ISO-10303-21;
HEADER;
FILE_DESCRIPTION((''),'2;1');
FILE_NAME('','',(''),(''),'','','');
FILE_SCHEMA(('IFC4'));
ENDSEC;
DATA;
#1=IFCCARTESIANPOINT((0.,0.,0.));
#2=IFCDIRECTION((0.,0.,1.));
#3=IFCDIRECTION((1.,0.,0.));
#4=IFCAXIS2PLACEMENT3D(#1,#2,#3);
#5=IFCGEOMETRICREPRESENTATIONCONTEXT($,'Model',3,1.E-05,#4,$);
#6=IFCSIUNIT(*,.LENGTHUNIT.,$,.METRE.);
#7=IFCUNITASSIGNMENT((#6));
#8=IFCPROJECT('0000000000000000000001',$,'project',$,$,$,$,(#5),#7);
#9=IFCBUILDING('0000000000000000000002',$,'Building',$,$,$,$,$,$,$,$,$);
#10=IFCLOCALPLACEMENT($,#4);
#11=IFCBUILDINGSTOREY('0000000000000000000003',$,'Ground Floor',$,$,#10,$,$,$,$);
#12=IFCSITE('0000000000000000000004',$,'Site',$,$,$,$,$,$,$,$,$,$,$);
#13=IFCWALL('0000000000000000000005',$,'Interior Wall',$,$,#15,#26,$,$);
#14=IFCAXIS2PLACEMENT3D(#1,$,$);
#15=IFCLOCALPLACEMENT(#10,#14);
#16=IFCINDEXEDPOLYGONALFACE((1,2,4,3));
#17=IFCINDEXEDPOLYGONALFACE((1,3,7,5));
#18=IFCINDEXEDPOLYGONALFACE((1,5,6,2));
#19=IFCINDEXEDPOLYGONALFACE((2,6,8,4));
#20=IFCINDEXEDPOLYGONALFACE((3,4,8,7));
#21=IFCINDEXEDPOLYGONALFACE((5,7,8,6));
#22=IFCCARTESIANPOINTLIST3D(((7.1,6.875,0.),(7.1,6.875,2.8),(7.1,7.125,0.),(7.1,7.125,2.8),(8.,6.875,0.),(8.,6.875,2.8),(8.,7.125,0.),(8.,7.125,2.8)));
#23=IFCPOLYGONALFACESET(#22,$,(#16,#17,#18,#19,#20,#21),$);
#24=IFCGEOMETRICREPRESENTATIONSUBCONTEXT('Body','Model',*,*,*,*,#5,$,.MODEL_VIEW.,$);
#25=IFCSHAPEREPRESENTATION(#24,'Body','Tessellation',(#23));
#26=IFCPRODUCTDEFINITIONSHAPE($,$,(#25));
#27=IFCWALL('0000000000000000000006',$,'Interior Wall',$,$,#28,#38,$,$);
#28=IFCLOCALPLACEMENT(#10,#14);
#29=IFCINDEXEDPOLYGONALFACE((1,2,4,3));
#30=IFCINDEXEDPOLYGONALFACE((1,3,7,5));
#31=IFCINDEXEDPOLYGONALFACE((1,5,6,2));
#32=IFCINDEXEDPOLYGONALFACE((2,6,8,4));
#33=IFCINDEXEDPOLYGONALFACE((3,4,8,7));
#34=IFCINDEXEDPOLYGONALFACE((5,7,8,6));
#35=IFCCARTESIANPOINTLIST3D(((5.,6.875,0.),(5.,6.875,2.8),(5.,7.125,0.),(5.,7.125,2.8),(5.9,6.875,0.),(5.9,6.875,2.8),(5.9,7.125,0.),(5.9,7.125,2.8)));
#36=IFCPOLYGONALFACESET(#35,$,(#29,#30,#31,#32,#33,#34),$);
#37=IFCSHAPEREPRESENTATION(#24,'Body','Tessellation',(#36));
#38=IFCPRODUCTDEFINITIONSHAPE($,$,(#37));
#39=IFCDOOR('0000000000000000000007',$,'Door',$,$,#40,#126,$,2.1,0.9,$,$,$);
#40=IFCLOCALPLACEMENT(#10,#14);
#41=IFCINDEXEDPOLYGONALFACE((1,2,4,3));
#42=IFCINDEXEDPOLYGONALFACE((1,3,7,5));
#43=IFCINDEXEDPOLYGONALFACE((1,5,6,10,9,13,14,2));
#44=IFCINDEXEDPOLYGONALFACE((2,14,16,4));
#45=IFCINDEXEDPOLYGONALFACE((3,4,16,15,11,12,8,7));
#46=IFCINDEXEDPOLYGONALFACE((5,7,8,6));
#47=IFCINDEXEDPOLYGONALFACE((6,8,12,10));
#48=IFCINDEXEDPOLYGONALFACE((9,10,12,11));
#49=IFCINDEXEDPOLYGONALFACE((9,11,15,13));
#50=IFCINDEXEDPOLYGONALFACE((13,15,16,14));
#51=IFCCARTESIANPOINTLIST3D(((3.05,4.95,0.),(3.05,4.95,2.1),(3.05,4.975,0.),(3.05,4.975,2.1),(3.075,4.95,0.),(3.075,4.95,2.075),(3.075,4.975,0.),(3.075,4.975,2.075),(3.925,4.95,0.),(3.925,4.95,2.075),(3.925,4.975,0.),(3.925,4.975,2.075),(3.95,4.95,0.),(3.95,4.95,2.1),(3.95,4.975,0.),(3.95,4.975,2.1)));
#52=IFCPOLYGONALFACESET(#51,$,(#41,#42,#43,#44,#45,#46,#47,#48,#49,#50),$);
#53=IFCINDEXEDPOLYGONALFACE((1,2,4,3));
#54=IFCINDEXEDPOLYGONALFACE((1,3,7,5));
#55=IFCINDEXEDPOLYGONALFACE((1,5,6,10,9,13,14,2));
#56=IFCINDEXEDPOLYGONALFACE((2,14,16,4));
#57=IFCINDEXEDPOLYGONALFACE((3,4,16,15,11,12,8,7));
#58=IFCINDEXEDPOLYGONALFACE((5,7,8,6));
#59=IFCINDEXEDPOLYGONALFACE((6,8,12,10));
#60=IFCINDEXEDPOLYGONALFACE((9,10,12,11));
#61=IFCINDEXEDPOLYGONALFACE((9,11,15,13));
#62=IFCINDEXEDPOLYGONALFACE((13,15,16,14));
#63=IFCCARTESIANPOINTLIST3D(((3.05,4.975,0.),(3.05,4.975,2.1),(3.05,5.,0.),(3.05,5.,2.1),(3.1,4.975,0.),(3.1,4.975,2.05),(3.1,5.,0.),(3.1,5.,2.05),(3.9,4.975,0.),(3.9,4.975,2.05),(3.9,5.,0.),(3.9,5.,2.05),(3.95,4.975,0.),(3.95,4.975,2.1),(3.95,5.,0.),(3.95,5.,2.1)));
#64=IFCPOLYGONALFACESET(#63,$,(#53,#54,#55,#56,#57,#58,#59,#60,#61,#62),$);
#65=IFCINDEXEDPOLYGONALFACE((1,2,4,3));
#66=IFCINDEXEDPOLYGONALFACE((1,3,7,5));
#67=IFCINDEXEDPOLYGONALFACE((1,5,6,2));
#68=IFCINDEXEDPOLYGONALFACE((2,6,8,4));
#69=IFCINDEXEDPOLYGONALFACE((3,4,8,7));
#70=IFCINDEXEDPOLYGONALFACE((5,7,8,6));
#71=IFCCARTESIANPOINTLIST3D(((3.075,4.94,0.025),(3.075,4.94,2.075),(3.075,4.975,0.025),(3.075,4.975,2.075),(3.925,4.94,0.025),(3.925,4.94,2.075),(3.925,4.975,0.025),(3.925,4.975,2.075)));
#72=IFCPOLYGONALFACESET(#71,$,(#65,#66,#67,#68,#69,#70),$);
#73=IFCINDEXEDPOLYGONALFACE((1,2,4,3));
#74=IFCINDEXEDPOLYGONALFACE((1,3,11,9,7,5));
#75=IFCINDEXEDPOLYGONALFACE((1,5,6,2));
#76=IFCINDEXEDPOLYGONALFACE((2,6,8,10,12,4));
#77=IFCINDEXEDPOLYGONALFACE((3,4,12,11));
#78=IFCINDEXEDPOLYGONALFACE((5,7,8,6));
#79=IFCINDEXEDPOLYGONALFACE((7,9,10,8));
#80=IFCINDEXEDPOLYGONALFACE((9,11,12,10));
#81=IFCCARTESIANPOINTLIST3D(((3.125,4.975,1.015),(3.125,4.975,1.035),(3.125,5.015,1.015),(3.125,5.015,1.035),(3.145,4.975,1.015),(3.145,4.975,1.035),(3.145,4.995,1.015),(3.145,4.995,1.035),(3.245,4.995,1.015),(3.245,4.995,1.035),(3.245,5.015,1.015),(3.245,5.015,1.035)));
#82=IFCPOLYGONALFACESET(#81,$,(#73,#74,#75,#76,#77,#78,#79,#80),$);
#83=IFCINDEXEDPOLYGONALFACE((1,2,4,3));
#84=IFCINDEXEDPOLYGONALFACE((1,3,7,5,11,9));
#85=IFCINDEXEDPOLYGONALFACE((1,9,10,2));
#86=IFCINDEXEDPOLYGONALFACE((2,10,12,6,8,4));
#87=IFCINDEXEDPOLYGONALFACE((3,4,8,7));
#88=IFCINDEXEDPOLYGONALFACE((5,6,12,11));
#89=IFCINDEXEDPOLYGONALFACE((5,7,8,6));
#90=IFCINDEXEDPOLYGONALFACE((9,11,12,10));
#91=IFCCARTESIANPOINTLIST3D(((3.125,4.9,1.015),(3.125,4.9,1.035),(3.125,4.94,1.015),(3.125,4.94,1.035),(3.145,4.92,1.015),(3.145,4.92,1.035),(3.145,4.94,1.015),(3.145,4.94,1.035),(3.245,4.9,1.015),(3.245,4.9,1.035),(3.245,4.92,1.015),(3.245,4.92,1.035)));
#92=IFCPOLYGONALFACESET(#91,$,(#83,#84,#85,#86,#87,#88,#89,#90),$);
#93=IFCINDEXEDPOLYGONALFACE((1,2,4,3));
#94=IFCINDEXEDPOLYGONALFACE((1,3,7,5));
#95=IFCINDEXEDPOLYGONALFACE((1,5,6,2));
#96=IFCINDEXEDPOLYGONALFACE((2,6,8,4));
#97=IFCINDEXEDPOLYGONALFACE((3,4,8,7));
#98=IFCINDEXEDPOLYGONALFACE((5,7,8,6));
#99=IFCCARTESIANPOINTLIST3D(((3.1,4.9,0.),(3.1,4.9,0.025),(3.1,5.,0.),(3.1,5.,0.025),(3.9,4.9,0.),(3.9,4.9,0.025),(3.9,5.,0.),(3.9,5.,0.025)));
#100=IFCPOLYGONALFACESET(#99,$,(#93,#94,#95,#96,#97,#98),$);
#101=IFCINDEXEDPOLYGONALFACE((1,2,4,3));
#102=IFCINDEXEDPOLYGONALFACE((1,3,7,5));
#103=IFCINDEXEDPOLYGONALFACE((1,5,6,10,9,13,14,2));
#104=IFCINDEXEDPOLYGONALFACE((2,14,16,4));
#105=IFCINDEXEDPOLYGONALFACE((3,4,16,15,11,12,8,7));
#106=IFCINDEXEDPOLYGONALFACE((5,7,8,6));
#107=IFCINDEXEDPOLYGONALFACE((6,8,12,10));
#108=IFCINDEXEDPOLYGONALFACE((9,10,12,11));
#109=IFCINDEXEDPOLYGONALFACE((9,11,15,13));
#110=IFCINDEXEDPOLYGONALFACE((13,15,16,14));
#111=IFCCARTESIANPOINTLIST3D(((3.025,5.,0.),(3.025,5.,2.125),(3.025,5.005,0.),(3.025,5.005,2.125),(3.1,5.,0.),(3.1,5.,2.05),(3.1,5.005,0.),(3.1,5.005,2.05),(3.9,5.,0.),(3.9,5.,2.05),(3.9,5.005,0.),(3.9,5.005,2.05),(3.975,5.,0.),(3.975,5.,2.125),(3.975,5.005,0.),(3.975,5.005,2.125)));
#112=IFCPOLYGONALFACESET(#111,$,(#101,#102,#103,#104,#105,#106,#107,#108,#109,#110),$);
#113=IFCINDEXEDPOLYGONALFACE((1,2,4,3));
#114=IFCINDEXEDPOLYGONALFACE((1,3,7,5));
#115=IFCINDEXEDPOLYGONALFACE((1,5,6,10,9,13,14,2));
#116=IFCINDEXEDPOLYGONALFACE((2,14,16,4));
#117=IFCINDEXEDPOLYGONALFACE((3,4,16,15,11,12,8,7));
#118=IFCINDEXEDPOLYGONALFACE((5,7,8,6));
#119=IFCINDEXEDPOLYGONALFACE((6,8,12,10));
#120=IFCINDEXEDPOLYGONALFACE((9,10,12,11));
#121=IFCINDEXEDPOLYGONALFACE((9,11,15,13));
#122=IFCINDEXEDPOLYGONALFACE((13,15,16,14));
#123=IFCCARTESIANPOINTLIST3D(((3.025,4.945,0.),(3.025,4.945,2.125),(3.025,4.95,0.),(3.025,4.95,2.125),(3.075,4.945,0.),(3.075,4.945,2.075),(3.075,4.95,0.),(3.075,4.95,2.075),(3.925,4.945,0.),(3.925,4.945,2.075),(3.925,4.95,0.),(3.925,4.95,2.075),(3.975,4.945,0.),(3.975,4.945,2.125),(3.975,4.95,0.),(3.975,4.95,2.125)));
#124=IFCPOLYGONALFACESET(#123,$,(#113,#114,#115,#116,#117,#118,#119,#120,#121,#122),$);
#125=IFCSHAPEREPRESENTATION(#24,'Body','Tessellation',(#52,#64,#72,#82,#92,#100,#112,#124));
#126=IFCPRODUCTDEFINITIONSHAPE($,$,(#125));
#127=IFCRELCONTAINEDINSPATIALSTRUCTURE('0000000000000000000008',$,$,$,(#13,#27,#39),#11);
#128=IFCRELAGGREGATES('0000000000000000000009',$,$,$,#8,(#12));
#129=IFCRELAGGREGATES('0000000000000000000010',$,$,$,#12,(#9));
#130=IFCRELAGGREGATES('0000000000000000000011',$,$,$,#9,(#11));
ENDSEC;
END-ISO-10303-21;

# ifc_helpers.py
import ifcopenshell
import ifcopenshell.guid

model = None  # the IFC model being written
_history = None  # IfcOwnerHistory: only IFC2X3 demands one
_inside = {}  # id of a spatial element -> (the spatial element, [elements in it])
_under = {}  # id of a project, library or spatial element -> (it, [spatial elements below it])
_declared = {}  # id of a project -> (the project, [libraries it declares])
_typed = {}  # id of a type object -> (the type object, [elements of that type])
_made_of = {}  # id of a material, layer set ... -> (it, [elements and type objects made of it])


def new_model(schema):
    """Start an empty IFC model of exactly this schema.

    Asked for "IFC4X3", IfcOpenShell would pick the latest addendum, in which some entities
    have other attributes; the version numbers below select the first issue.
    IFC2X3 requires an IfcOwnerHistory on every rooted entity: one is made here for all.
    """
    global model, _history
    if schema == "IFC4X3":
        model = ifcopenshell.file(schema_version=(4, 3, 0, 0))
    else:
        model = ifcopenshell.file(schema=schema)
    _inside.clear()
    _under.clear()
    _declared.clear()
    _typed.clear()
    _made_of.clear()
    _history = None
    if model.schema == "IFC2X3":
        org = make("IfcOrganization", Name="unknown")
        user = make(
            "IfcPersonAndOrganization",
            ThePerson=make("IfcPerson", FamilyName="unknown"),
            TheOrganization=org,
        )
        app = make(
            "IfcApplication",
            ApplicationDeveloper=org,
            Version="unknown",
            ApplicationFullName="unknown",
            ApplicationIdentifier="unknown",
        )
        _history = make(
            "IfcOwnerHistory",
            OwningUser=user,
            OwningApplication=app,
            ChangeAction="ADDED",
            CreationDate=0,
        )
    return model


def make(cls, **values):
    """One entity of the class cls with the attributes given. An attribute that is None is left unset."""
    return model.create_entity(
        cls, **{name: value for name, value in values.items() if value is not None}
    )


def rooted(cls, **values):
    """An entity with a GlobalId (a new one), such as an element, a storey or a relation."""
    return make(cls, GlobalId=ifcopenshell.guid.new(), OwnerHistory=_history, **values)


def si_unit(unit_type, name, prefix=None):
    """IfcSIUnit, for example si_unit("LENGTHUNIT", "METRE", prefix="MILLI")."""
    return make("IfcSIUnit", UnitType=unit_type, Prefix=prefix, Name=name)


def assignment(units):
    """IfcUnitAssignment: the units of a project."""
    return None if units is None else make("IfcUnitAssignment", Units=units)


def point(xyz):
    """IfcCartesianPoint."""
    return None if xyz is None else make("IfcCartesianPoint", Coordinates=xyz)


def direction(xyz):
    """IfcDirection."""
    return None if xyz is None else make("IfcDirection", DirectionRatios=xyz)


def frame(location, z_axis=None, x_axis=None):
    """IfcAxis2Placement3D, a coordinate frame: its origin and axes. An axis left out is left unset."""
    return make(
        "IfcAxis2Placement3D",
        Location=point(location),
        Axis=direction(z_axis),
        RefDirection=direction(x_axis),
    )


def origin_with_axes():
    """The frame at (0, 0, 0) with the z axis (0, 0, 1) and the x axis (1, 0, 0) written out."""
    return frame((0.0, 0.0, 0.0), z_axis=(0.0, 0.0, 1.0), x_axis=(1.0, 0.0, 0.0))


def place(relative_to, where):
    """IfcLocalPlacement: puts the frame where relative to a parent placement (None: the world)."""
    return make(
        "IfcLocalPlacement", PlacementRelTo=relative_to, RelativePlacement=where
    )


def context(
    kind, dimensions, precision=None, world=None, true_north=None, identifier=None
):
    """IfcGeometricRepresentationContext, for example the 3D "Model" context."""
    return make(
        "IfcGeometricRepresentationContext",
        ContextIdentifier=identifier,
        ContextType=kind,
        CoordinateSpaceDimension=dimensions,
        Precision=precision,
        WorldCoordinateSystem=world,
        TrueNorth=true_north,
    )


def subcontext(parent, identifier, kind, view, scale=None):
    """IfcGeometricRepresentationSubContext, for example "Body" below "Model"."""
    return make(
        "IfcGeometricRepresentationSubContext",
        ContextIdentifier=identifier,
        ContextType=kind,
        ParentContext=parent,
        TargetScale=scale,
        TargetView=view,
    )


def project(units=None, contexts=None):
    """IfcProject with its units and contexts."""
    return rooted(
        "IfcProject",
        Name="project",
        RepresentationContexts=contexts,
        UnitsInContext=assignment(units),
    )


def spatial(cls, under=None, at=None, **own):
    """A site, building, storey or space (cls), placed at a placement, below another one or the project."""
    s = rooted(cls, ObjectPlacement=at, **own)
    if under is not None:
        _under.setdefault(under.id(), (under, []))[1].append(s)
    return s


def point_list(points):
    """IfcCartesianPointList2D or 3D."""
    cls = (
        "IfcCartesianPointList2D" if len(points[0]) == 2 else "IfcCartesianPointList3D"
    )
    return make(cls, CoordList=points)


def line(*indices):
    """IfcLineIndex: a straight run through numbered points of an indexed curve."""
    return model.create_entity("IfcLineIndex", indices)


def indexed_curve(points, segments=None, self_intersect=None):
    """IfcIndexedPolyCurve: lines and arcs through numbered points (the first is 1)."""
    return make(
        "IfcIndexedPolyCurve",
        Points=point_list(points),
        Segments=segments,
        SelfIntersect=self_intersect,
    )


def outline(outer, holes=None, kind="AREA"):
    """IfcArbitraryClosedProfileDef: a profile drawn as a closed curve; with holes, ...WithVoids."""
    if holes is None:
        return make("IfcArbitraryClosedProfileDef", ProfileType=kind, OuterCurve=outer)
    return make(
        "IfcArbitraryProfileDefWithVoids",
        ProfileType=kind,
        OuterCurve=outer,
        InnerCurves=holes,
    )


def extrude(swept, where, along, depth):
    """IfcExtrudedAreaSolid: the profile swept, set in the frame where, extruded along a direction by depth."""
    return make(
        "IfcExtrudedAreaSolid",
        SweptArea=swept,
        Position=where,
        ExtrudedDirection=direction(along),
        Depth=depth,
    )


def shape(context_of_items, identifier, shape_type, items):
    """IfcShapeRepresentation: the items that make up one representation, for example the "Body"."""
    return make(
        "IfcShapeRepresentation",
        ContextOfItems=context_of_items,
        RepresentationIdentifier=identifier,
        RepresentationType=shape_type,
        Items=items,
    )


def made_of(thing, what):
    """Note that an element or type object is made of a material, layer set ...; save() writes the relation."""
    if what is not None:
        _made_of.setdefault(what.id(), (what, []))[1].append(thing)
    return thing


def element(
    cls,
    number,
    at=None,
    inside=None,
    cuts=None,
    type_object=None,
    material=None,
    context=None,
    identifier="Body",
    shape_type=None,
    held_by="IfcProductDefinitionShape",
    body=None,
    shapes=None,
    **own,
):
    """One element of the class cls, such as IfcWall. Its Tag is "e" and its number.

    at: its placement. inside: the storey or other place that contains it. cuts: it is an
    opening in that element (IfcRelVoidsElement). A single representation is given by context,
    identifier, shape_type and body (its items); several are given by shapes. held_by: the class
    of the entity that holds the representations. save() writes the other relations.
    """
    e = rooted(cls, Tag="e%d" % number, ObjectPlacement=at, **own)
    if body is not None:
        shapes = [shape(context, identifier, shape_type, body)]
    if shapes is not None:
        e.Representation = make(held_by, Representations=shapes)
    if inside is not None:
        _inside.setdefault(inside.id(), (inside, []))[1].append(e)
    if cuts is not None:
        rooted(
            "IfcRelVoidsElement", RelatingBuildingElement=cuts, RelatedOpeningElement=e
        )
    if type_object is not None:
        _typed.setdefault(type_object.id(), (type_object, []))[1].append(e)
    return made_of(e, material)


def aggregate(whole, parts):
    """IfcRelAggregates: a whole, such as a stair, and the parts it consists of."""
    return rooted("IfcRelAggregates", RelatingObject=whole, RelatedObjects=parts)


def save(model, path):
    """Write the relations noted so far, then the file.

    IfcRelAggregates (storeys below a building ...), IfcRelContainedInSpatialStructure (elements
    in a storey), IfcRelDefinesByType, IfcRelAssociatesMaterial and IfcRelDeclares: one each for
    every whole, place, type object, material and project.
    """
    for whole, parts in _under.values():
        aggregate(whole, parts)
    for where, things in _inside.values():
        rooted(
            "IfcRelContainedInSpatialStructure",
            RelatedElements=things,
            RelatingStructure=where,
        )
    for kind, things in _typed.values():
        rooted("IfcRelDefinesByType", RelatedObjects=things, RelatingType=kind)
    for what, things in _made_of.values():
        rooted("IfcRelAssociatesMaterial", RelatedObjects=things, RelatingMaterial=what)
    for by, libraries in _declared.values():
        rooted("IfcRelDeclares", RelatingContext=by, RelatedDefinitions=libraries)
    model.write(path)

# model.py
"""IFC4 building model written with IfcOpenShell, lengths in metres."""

from ifc_helpers import new_model, si_unit, frame, origin_with_axes, place, context, subcontext, project, spatial, line, indexed_curve, outline, extrude, element, save


model = new_model("IFC4")

# Units and contexts
model_context = context("Model", 3, precision=1e-05, world=origin_with_axes())
body_context = subcontext(model_context, "Body", "Model", "MODEL_VIEW")
ifc_project = project(units=[si_unit("LENGTHUNIT", "METRE")], contexts=[model_context])

# Site, building, storey
site = spatial("IfcSite", under=ifc_project, Name="Site")
building = spatial("IfcBuilding", under=site, Name="Building")
storey_placement = place(None, origin_with_axes())
storey = spatial("IfcBuildingStorey", under=building, at=storey_placement, Name="Ground Floor")

# Walls
for number, where, z_axis, x_axis, name in (
    (1, (8.0, 7.0, 0.0), (0.0, 0.0, 1.0), (-1.0, 0.0, 0.0), "Interior Wall"),
    (2, (5.9, 7.0, 0.0), (0.0, 0.0, 1.0), (-1.0, 0.0, 0.0), "Interior Wall"),
):
    element("IfcWall", number, at=place(storey_placement, frame(where, z_axis=z_axis, x_axis=x_axis)), inside=storey, Name=name, context=body_context, shape_type="SweptSolid", body=[
        extrude(outline(indexed_curve([(0.0, 0.0), (0.0, 0.25), (0.9, 0.25), (0.9, 0.0), (0.0, 0.0)], self_intersect=False)), frame((0.0, -0.125, 0.0), z_axis=(0.0, 0.0, 1.0), x_axis=(1.0, 0.0, 0.0)), (0.0, 0.0, 1.0), 2.8),
    ])

# Door
door_1_placement = place(storey_placement, frame((3.95, 5.0, 0.0), z_axis=(0.0, 0.0, 1.0), x_axis=(-1.0, 0.0, 0.0)))
element("IfcDoor", 3, at=door_1_placement, inside=storey, Name="Door", OverallHeight=2.1, OverallWidth=0.9, context=body_context, shape_type="SweptSolid", body=[
    extrude(outline(indexed_curve([(0.0, 0.0), (0.0, 2.1), (0.9, 2.1), (0.9, 0.0), (0.875, 0.0), (0.875, 2.075), (0.025, 2.075), (0.025, 0.0)], segments=[line(1, 2, 3, 4, 5, 6, 7, 8, 1)])), frame((0.0, 0.025, 0.0), z_axis=(0.0, -1.0, 0.0), x_axis=(1.0, 0.0, 0.0)), (0.0, 0.0, -1.0), 0.025),
    extrude(outline(indexed_curve([(0.0, 0.0), (0.0, 2.1), (0.9, 2.1), (0.9, 0.0), (0.85, 0.0), (0.85, 2.05), (0.05, 2.05), (0.05, 0.0)], segments=[line(1, 2, 3, 4, 5, 6, 7, 8, 1)])), frame((0.0, 0.0, 0.0), z_axis=(0.0, -1.0, 0.0), x_axis=(1.0, 0.0, 0.0)), (0.0, 0.0, -1.0), 0.025),
    extrude(outline(indexed_curve([(0.0, 0.0), (0.85, 0.0), (0.85, 0.035), (0.0, 0.035)], segments=[line(1, 2, 3, 4, 1)])), frame((0.025, 0.025, 0.025), z_axis=(0.0, 0.0, 1.0), x_axis=(1.0, 0.0, 0.0)), (0.0, 0.0, 1.0), 2.05),
    extrude(outline(indexed_curve([(0.0, 0.0), (0.0, -0.04), (-0.12, -0.04), (-0.12, -0.02), (-0.02, -0.02), (-0.02, 0.0)], segments=[line(1, 2, 3, 4, 5, 6, 1)])), frame((0.825, 0.025, 1.015), z_axis=(0.0, 0.0, 1.0), x_axis=(1.0, 0.0, 0.0)), (0.0, 0.0, 1.0), 0.02),
    extrude(outline(indexed_curve([(0.0, 0.0), (0.0, 0.04), (-0.12, 0.04), (-0.12, 0.02), (-0.02, 0.02), (-0.02, 0.0)], segments=[line(1, 2, 3, 4, 5, 6, 1)])), frame((0.825, 0.06, 1.015), z_axis=(0.0, 0.0, 1.0), x_axis=(1.0, 0.0, 0.0)), (0.0, 0.0, 1.0), 0.02),
    extrude(outline(indexed_curve([(0.0, 0.0), (0.8, 0.0), (0.8, 0.1), (0.0, 0.1)], segments=[line(1, 2, 3, 4, 1)])), frame((0.05, 0.0, 0.0), z_axis=(0.0, 0.0, 1.0), x_axis=(1.0, 0.0, 0.0)), (0.0, 0.0, 1.0), 0.025),
    extrude(outline(indexed_curve([(0.0, 0.0), (0.0, 2.125), (0.95, 2.125), (0.95, 0.0), (0.875, 0.0), (0.875, 2.05), (0.075, 2.05), (0.075, 0.0)], segments=[line(1, 2, 3, 4, 5, 6, 7, 8, 1)])), frame((-0.025, -0.005, 0.0), z_axis=(0.0, -1.0, 0.0), x_axis=(1.0, 0.0, 0.0)), (0.0, 0.0, -1.0), 0.005),
    extrude(outline(indexed_curve([(0.0, 0.0), (0.0, 2.125), (0.95, 2.125), (0.95, 0.0), (0.9, 0.0), (0.9, 2.075), (0.05, 2.075), (0.05, 0.0)], segments=[line(1, 2, 3, 4, 5, 6, 7, 8, 1)])), frame((-0.025, 0.05, 0.0), z_axis=(0.0, -1.0, 0.0), x_axis=(1.0, 0.0, 0.0)), (0.0, 0.0, -1.0), 0.005),
])

save(model, "model.ifc")
